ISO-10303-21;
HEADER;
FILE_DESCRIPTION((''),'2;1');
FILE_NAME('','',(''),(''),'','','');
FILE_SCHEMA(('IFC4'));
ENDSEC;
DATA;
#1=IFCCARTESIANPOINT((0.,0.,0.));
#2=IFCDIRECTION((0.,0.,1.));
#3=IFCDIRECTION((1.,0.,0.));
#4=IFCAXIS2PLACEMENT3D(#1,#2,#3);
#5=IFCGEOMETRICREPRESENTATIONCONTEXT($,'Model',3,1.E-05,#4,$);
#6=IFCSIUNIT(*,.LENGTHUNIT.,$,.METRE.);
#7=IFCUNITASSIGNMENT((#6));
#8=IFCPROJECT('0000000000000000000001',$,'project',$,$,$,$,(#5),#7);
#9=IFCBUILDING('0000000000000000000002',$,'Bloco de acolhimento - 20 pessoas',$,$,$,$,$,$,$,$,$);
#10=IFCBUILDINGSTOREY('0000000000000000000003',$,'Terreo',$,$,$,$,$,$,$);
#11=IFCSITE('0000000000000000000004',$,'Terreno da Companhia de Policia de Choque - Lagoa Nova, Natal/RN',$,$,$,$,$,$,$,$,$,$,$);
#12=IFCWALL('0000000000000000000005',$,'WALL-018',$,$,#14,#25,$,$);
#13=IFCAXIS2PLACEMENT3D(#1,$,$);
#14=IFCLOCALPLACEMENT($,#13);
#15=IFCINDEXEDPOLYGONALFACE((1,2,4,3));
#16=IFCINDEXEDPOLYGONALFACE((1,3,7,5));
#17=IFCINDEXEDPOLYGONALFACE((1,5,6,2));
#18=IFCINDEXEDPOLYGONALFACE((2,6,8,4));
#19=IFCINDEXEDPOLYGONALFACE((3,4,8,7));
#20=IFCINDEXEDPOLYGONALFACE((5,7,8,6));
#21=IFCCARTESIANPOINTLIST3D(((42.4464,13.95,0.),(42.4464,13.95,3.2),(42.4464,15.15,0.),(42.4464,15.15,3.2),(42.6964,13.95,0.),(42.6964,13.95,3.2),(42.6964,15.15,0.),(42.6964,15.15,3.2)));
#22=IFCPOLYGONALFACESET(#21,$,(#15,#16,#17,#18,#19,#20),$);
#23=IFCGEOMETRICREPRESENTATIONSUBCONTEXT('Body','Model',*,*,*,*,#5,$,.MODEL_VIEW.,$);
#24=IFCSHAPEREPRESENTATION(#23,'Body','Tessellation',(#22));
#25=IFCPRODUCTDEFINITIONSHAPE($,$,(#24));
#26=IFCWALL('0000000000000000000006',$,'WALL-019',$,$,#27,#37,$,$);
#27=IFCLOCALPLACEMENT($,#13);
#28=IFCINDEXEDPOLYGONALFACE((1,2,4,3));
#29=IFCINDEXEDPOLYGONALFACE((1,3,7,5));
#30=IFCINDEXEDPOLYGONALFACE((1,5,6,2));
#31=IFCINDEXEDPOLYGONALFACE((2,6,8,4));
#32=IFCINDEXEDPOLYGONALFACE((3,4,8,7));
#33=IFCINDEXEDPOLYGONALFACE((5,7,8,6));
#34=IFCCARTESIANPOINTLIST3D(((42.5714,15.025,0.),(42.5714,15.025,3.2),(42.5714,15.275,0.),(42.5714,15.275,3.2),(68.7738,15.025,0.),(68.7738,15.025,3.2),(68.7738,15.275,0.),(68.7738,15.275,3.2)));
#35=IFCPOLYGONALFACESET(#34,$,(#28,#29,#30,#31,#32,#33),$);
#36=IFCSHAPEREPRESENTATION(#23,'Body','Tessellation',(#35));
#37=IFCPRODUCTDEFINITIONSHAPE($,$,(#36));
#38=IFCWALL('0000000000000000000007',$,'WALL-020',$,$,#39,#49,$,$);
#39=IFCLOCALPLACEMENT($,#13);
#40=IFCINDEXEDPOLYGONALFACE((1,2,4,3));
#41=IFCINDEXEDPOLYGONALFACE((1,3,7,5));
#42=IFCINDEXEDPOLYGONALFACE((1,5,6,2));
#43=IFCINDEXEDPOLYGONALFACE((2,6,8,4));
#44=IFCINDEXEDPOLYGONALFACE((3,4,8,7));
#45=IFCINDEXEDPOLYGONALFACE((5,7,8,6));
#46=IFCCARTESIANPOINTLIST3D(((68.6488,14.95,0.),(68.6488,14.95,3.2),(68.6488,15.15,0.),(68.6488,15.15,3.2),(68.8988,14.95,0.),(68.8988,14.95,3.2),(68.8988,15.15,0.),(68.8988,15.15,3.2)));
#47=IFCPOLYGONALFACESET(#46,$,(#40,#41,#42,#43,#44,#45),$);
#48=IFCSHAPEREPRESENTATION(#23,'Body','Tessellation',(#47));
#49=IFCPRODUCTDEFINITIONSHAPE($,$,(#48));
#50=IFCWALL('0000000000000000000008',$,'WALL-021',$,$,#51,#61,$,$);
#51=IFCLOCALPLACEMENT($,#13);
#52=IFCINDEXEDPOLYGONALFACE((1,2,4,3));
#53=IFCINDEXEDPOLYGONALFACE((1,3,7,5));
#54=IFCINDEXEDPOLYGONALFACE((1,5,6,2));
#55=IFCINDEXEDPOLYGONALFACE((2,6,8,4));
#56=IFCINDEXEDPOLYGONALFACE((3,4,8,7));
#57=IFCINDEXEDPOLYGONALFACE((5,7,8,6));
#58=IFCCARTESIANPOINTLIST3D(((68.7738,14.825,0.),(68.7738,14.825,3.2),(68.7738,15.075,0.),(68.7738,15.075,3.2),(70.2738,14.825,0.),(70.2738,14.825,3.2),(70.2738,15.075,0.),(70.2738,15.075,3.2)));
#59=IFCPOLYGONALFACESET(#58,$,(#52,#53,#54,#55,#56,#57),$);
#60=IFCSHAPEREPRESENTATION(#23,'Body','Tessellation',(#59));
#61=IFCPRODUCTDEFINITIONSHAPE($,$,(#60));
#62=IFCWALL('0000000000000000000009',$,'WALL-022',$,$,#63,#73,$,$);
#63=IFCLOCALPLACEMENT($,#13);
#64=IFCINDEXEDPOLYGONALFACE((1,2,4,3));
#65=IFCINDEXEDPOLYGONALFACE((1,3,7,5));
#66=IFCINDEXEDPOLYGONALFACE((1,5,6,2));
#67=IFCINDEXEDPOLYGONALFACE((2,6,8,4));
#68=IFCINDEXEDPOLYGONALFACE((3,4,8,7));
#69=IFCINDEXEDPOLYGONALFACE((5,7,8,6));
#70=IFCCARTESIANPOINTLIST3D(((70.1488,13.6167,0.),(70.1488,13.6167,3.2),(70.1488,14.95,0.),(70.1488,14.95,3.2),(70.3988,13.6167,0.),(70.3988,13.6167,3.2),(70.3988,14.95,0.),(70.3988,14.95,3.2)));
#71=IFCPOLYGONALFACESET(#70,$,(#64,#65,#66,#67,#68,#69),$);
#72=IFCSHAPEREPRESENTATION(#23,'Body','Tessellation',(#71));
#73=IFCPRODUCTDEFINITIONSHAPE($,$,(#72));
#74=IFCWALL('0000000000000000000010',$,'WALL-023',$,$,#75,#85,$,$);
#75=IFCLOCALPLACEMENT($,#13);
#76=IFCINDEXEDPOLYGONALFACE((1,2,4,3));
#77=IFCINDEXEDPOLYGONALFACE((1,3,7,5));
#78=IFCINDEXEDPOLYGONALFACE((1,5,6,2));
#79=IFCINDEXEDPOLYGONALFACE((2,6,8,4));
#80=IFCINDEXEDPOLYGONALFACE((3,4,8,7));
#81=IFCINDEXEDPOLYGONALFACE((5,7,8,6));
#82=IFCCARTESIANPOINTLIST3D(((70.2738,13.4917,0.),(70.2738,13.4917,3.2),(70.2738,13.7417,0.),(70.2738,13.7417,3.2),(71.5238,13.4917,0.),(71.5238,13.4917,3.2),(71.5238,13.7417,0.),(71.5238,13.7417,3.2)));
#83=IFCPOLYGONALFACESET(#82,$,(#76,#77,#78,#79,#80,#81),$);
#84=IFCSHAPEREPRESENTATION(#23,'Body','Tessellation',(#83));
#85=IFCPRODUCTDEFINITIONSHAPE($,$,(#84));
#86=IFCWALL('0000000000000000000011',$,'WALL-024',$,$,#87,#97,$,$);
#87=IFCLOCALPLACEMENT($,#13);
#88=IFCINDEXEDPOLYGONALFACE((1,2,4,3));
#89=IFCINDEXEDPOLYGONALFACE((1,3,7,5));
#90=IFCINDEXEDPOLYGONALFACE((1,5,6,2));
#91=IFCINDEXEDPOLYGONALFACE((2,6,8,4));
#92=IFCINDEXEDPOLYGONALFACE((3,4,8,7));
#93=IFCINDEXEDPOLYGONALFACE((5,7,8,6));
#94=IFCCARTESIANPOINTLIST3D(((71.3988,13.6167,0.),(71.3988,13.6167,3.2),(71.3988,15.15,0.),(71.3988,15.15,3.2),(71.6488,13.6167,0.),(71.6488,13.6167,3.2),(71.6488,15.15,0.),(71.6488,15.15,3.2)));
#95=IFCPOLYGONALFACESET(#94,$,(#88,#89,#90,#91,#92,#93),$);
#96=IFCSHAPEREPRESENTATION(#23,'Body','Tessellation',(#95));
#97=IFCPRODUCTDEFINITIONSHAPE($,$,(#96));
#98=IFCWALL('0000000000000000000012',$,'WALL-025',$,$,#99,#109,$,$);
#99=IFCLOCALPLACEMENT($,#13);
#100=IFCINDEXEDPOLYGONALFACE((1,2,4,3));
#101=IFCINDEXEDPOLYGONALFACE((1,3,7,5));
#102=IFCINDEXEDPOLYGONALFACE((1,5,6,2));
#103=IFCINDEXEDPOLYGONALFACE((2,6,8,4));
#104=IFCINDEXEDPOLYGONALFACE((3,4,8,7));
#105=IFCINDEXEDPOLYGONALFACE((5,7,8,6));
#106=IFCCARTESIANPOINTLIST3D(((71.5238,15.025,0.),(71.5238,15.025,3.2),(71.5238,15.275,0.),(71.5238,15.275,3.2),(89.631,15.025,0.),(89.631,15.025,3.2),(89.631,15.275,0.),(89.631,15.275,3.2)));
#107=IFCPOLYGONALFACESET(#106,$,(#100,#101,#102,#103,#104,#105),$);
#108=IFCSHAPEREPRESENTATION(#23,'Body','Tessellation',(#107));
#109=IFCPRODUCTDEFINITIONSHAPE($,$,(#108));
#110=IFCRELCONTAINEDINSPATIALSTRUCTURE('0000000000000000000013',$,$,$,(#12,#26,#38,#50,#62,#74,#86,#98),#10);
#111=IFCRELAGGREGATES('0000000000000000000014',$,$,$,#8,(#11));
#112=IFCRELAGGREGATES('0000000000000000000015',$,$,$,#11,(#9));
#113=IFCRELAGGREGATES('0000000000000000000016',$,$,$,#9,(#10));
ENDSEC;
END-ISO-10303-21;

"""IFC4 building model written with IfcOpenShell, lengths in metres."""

from ifc_helpers import new_model, si_unit, origin_with_axes, place, context, subcontext, project, spatial, polyline, outline, extrude, element, save


model = new_model("IFC4")

# Units and contexts
model_context = context("Model", 3, precision=1e-05, world=origin_with_axes())
body_context = subcontext(model_context, "Body", "Model", "MODEL_VIEW")
ifc_project = project(units=[si_unit("LENGTHUNIT", "METRE")], contexts=[model_context])

# Site, building, storey
site = spatial("IfcSite", under=ifc_project, Name="Terreno da Companhia de Policia de Choque - Lagoa Nova, Natal/RN")
building = spatial("IfcBuilding", under=site, Name="Bloco de acolhimento - 20 pessoas")
storey = spatial("IfcBuildingStorey", under=building, Name="Terreo")

# Walls
wall_1_placement = place(None, origin_with_axes())
element("IfcWall", 1, at=wall_1_placement, inside=storey, Name="WALL-018", context=body_context, shape_type="SweptSolid", body=[
    extrude(outline(polyline([(42.6964, 13.95, 0.0), (42.6964, 15.15, 0.0), (42.4464, 15.15, 0.0), (42.4464, 13.95, 0.0), (42.6964, 13.95, 0.0)])), None, (0.0, 0.0, 1.0), 3.2),
])
wall_2_placement = place(None, origin_with_axes())
element("IfcWall", 2, at=wall_2_placement, inside=storey, Name="WALL-019", context=body_context, shape_type="SweptSolid", body=[
    extrude(outline(polyline([(68.7738, 15.025, 0.0), (68.7738, 15.275, 0.0), (42.5714, 15.275, 0.0), (42.5714, 15.025, 0.0), (68.7738, 15.025, 0.0)])), None, (0.0, 0.0, 1.0), 3.2),
])
wall_3_placement = place(None, origin_with_axes())
element("IfcWall", 3, at=wall_3_placement, inside=storey, Name="WALL-020", context=body_context, shape_type="SweptSolid", body=[
    extrude(outline(polyline([(68.8988, 14.95, 0.0), (68.8988, 15.15, 0.0), (68.6488, 15.15, 0.0), (68.6488, 14.95, 0.0), (68.8988, 14.95, 0.0)])), None, (0.0, 0.0, 1.0), 3.2),
])
wall_4_placement = place(None, origin_with_axes())
element("IfcWall", 4, at=wall_4_placement, inside=storey, Name="WALL-021", context=body_context, shape_type="SweptSolid", body=[
    extrude(outline(polyline([(70.2738, 14.825, 0.0), (70.2738, 15.075, 0.0), (68.7738, 15.075, 0.0), (68.7738, 14.825, 0.0), (70.2738, 14.825, 0.0)])), None, (0.0, 0.0, 1.0), 3.2),
])
wall_5_placement = place(None, origin_with_axes())
element("IfcWall", 5, at=wall_5_placement, inside=storey, Name="WALL-022", context=body_context, shape_type="SweptSolid", body=[
    extrude(outline(polyline([(70.3988, 13.6167, 0.0), (70.3988, 14.95, 0.0), (70.1488, 14.95, 0.0), (70.1488, 13.6167, 0.0), (70.3988, 13.6167, 0.0)])), None, (0.0, 0.0, 1.0), 3.2),
])
wall_6_placement = place(None, origin_with_axes())
element("IfcWall", 6, at=wall_6_placement, inside=storey, Name="WALL-023", context=body_context, shape_type="SweptSolid", body=[
    extrude(outline(polyline([(71.5238, 13.4917, 0.0), (71.5238, 13.7417, 0.0), (70.2738, 13.7417, 0.0), (70.2738, 13.4917, 0.0), (71.5238, 13.4917, 0.0)])), None, (0.0, 0.0, 1.0), 3.2),
])
wall_7_placement = place(None, origin_with_axes())
element("IfcWall", 7, at=wall_7_placement, inside=storey, Name="WALL-024", context=body_context, shape_type="SweptSolid", body=[
    extrude(outline(polyline([(71.6488, 13.6167, 0.0), (71.6488, 15.15, 0.0), (71.3988, 15.15, 0.0), (71.3988, 13.6167, 0.0), (71.6488, 13.6167, 0.0)])), None, (0.0, 0.0, 1.0), 3.2),
])
wall_8_placement = place(None, origin_with_axes())
element("IfcWall", 8, at=wall_8_placement, inside=storey, Name="WALL-025", context=body_context, shape_type="SweptSolid", body=[
    extrude(outline(polyline([(89.631, 15.025, 0.0), (89.631, 15.275, 0.0), (71.5238, 15.275, 0.0), (71.5238, 15.025, 0.0), (89.631, 15.025, 0.0)])), None, (0.0, 0.0, 1.0), 3.2),
])

save(model, "model.ifc")
